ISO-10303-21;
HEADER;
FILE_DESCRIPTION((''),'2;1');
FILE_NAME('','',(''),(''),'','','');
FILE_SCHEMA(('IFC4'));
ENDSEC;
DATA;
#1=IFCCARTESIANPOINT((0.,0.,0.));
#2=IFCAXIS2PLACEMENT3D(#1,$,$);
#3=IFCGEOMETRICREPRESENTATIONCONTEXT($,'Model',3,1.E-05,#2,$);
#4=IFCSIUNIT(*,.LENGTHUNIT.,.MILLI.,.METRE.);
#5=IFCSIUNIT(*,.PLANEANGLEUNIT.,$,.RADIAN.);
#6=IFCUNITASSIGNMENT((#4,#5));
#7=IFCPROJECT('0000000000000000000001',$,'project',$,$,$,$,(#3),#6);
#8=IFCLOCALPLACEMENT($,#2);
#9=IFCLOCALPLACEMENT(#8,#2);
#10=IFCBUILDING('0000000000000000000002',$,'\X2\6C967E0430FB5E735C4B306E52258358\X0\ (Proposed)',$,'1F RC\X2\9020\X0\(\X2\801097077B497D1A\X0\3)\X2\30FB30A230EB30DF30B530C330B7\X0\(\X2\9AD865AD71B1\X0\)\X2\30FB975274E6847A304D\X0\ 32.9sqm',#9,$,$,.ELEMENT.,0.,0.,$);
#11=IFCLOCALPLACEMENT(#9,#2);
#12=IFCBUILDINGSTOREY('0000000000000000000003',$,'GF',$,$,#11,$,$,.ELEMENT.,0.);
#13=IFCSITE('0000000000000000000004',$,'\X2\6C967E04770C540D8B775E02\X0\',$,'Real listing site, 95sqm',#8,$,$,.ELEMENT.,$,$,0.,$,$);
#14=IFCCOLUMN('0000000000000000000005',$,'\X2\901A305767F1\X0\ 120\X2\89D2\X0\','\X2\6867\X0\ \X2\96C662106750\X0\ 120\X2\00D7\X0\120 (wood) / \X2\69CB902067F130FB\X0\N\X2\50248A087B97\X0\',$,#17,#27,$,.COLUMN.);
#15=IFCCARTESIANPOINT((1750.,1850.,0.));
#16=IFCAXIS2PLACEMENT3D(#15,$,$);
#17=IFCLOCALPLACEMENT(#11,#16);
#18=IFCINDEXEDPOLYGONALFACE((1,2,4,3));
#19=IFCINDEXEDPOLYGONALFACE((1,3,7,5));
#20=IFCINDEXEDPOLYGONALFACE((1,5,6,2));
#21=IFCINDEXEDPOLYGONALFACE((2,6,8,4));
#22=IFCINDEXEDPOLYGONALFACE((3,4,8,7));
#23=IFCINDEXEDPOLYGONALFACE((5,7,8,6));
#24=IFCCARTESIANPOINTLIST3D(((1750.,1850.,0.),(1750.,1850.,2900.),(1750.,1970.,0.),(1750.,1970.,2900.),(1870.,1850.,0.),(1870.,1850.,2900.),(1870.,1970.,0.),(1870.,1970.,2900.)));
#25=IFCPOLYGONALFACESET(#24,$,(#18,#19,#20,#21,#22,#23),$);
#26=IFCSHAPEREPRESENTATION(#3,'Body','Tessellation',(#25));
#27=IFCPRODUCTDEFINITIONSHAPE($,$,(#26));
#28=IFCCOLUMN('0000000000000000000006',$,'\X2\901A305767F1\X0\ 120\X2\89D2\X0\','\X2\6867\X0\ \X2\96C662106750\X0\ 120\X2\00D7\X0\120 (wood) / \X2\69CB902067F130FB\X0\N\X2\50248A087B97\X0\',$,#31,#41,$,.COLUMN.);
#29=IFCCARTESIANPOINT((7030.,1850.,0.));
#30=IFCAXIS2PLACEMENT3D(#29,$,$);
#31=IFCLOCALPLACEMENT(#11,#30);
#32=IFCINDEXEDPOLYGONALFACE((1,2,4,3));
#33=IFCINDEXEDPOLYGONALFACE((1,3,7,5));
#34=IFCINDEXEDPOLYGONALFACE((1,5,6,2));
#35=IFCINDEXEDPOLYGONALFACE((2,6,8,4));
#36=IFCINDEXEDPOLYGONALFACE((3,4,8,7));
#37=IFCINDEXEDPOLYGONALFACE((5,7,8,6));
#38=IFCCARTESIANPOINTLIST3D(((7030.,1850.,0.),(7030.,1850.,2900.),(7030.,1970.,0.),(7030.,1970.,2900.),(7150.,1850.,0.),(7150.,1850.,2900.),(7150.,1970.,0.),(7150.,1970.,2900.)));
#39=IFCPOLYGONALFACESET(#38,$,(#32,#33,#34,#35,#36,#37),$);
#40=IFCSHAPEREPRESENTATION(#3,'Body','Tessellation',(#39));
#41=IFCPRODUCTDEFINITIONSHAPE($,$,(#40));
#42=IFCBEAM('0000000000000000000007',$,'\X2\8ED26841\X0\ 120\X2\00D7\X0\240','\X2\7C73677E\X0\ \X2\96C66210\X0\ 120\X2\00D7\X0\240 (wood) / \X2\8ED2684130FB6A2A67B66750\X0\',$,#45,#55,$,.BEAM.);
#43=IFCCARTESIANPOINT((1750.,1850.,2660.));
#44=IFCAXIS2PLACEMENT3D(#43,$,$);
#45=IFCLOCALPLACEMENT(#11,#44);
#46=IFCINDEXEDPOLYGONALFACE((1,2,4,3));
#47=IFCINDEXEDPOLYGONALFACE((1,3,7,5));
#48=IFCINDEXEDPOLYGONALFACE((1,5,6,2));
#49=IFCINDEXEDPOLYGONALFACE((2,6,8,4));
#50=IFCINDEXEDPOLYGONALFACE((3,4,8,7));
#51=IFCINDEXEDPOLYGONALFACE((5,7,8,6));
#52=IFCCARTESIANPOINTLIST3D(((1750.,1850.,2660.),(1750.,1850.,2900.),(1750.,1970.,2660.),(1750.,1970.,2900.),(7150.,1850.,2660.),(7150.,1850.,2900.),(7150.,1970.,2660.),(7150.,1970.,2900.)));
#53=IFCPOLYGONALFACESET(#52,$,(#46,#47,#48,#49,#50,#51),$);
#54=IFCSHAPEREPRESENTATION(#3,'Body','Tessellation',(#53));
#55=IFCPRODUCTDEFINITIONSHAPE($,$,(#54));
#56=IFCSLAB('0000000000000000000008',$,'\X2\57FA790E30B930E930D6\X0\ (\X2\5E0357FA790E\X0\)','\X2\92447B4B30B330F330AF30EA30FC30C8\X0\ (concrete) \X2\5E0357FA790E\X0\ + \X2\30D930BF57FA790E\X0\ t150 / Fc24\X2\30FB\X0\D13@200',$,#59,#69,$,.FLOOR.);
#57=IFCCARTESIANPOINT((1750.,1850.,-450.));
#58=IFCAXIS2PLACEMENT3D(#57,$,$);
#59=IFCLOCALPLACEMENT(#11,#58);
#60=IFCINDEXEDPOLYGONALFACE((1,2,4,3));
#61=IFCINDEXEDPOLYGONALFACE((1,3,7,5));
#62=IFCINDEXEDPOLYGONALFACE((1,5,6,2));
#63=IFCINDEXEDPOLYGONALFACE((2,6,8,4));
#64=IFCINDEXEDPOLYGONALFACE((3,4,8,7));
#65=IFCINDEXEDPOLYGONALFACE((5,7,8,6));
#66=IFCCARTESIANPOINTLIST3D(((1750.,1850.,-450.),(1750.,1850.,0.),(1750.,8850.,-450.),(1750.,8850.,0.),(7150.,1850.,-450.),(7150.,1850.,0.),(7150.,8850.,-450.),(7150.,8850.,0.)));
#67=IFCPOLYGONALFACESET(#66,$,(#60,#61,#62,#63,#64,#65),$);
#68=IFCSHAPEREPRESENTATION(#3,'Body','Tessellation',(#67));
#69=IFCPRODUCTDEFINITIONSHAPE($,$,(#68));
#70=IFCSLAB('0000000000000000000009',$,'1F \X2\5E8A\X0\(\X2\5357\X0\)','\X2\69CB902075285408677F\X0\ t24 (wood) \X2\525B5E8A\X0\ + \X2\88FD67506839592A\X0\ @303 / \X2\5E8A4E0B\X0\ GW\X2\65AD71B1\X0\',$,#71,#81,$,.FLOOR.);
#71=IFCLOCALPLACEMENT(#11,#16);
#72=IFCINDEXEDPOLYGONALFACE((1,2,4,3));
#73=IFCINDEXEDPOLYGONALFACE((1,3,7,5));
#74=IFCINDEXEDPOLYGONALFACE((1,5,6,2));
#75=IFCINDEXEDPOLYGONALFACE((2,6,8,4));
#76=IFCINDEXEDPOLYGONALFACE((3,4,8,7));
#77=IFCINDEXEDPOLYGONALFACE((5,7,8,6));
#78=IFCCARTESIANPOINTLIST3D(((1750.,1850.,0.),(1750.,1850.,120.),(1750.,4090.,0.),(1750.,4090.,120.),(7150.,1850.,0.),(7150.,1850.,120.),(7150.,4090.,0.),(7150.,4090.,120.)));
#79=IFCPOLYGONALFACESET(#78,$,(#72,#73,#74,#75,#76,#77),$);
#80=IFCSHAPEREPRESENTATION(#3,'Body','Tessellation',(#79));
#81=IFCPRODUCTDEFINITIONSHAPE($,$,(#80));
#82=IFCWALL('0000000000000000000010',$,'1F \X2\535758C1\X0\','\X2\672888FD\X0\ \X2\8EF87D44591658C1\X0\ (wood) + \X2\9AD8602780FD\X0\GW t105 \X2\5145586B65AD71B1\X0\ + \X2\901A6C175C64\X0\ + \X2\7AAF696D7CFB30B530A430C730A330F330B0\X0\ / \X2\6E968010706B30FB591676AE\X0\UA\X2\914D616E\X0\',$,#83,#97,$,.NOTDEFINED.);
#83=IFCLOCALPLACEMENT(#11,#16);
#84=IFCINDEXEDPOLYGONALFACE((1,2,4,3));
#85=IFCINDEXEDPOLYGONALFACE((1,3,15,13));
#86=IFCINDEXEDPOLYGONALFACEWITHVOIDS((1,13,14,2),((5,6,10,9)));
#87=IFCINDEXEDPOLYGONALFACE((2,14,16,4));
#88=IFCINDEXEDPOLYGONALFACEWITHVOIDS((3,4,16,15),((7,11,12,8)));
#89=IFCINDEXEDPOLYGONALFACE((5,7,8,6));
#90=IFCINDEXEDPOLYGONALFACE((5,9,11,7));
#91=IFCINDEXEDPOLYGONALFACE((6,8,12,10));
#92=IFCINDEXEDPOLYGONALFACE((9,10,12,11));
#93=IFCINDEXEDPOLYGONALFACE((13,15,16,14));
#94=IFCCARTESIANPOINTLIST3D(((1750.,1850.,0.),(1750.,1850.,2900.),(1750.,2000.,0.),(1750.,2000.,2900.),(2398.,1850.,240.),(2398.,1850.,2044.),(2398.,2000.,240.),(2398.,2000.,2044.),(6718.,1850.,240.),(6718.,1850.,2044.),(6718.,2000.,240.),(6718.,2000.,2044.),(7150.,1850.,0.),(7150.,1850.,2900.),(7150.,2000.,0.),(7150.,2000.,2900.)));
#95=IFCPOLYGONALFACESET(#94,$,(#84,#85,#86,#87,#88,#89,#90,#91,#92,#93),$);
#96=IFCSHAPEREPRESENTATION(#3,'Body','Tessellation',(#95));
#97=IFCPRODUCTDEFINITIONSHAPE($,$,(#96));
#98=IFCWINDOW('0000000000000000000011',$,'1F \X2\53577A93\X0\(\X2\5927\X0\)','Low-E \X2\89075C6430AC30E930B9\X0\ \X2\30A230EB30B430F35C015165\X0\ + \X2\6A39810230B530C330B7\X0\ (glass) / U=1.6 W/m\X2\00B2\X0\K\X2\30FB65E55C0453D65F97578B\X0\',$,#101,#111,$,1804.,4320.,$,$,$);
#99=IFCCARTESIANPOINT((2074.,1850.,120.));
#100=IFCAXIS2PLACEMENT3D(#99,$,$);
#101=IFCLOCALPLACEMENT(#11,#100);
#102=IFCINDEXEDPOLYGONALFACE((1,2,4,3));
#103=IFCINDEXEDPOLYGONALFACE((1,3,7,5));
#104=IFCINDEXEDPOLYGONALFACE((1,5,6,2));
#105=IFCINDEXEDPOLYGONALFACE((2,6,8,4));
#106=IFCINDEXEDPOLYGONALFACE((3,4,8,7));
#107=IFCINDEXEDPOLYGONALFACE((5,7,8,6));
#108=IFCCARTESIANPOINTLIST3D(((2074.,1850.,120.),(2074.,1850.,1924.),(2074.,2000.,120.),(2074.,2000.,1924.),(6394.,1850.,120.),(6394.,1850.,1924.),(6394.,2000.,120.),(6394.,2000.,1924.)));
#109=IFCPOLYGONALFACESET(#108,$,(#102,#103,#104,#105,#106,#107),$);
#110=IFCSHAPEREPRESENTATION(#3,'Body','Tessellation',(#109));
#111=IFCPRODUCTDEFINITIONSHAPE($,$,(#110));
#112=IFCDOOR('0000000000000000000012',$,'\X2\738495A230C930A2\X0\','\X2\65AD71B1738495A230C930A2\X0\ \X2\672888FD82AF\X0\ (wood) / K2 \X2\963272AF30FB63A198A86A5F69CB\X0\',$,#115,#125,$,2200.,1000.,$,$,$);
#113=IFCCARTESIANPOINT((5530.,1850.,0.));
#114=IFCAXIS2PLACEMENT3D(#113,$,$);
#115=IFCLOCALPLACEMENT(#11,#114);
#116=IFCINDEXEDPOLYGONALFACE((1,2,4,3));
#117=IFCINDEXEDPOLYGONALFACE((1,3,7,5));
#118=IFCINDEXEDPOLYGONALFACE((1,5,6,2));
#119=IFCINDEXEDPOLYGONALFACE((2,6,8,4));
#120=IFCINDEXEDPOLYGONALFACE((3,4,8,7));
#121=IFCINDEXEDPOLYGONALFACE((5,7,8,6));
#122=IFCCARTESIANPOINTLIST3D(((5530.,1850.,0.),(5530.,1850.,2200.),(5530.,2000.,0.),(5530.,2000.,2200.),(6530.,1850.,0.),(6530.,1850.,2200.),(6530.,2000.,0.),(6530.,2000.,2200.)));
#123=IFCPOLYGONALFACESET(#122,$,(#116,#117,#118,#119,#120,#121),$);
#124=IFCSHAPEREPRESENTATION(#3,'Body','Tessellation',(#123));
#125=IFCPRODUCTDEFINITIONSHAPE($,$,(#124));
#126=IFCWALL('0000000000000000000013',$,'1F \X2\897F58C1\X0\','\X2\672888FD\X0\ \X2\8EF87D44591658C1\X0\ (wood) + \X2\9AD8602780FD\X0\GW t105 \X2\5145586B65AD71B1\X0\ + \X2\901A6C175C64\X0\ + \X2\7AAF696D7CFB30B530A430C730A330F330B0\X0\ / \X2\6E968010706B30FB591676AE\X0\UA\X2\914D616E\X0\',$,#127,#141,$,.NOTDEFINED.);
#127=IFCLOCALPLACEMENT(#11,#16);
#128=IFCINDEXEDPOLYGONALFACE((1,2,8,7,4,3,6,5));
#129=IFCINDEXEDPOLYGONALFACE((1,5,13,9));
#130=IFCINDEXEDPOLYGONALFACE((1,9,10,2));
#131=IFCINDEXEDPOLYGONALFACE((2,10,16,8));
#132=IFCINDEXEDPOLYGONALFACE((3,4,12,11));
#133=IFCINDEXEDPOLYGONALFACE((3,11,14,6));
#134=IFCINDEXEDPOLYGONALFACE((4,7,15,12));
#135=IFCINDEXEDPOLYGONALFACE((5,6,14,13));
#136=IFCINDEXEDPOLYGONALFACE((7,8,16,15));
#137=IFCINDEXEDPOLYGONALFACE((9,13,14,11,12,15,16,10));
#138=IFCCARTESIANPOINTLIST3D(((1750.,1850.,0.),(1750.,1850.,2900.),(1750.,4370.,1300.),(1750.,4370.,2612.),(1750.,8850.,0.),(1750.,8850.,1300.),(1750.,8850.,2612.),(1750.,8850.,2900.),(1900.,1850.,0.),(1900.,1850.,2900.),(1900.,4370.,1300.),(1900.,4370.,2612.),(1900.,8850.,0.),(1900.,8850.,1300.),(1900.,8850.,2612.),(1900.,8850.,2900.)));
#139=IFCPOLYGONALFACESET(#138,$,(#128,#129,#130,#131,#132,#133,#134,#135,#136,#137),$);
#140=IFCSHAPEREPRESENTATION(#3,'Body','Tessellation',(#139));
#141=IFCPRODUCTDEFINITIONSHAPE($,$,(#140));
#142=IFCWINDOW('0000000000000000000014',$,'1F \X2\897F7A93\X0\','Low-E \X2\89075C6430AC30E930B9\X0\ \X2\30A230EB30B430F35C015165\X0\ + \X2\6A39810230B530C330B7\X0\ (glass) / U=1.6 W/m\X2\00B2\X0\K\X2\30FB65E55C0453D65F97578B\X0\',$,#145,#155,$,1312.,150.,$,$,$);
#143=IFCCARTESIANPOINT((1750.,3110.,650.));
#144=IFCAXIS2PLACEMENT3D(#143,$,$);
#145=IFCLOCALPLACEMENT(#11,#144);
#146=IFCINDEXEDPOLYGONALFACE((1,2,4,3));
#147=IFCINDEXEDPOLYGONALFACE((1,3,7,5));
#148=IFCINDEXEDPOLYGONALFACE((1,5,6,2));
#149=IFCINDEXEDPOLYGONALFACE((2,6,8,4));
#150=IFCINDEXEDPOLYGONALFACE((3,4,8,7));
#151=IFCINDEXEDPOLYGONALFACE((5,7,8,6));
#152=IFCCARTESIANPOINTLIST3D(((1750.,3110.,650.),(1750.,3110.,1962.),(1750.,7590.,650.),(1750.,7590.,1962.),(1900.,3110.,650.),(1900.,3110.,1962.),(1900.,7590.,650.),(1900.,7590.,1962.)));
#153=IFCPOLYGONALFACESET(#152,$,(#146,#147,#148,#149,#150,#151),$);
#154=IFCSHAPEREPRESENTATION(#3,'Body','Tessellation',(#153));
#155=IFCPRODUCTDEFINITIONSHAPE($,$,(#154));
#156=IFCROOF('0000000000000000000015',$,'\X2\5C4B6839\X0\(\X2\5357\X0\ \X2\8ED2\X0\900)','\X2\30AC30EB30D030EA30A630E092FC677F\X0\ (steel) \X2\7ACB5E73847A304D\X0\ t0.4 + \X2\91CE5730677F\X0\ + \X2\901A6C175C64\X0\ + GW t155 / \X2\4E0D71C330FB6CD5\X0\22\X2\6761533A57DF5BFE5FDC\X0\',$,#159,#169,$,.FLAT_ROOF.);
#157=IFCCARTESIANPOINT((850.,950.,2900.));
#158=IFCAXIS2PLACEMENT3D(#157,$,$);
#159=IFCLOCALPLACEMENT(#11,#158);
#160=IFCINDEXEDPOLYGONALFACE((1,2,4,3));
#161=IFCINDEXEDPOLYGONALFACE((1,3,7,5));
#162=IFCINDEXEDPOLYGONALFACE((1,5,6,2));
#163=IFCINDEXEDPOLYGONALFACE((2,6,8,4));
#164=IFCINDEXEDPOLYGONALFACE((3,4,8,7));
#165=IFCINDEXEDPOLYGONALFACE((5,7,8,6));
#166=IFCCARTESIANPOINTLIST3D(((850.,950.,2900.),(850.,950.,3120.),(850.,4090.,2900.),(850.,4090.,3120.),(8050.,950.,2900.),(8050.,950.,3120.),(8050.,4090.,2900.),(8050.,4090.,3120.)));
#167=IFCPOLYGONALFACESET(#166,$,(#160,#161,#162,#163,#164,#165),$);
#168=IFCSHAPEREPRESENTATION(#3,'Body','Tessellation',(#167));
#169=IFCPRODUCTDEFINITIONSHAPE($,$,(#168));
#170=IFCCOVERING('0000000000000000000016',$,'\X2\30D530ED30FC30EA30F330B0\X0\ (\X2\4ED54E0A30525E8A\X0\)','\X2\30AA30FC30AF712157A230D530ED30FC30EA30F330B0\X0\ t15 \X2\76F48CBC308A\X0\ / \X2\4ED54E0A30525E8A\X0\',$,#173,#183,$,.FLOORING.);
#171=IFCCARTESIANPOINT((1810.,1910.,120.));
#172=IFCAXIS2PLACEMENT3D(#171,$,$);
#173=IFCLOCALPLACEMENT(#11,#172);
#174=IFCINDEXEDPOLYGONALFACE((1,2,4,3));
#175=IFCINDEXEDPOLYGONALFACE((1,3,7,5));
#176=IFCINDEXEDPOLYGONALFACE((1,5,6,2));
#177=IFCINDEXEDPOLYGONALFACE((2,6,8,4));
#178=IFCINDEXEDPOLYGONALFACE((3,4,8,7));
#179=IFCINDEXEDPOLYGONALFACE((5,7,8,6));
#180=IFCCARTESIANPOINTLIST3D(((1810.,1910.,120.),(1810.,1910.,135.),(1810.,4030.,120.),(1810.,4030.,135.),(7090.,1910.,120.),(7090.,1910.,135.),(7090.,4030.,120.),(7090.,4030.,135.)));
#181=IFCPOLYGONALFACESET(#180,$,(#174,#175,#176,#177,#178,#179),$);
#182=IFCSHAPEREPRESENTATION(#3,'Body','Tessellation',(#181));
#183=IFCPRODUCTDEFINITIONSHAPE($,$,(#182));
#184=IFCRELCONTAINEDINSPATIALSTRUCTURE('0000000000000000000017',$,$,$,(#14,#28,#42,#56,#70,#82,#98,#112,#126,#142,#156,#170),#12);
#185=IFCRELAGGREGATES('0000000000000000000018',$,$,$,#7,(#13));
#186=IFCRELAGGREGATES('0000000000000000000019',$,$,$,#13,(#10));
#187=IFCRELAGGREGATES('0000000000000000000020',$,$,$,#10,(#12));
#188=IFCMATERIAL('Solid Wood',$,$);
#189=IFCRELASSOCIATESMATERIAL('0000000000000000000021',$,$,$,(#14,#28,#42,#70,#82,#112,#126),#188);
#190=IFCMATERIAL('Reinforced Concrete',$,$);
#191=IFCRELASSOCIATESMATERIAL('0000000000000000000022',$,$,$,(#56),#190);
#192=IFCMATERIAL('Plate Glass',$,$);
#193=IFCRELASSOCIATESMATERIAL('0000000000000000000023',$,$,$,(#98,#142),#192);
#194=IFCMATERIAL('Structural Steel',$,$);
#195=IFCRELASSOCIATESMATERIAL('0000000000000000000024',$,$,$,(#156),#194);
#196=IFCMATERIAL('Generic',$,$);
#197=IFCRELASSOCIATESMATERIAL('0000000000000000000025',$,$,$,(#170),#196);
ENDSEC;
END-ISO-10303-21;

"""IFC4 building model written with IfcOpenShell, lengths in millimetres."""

from ifc_helpers import new_model, si_unit, frame, frame_2d, origin, place, context, project, spatial, rectangle, extrude, material, element, fill, save


model = new_model("IFC4")

# Units and contexts
model_context = context("Model", 3, precision=1e-05, world=origin())
ifc_project = project(units=[si_unit("LENGTHUNIT", "METRE", prefix="MILLI"), si_unit("PLANEANGLEUNIT", "RADIAN")], contexts=[model_context])

# Site, building, storey
site_placement = place(None, origin())
site = spatial("IfcSite", under=ifc_project, at=site_placement, Name="沖縄県名護市", ObjectType="Real listing site, 95sqm", CompositionType="ELEMENT", RefElevation=0.0)
building_placement = place(site_placement, origin())
building = spatial("IfcBuilding", under=site, at=building_placement, Name="沖縄・平屋の別荘 (Proposed)", ObjectType="1F RC造(耐震等級3)・アルミサッシ(高断熱)・青瓦葺き 32.9sqm", CompositionType="ELEMENT", ElevationOfRefHeight=0.0, ElevationOfTerrain=0.0)
storey_placement = place(building_placement, origin())
storey = spatial("IfcBuildingStorey", under=building, at=storey_placement, Name="GF", CompositionType="ELEMENT", Elevation=0.0)

# Columns
ifc_material_1 = material(Name="Solid Wood")
column_1_placement = place(storey_placement, frame((1750.0, 1850.0, 0.0)))
element("IfcColumn", 1, at=column_1_placement, inside=storey, material=ifc_material_1, Name="通し柱 120角", Description="桧 集成材 120×120 (wood) / 構造柱・N値計算", PredefinedType="COLUMN", context=model_context, shape_type="SweptSolid", body=[
    extrude(rectangle(XDim=120.0, YDim=120.0, at=frame_2d((60.0, 60.0))), frame((1750.0, 1850.0, 0.0)), (0.0, 0.0, 1.0), 2900.0),
])
column_2_placement = place(storey_placement, frame((7030.0, 1850.0, 0.0)))
element("IfcColumn", 2, at=column_2_placement, inside=storey, material=ifc_material_1, Name="通し柱 120角", Description="桧 集成材 120×120 (wood) / 構造柱・N値計算", PredefinedType="COLUMN", context=model_context, shape_type="SweptSolid", body=[
    extrude(rectangle(XDim=120.0, YDim=120.0, at=frame_2d((60.0, 60.0))), frame((7030.0, 1850.0, 0.0)), (0.0, 0.0, 1.0), 2900.0),
])

# Beam
beam_1_placement = place(storey_placement, frame((1750.0, 1850.0, 2660.0)))
element("IfcBeam", 3, at=beam_1_placement, inside=storey, material=ifc_material_1, Name="軒桁 120×240", Description="米松 集成 120×240 (wood) / 軒桁・横架材", PredefinedType="BEAM", context=model_context, shape_type="SweptSolid", body=[
    extrude(rectangle(XDim=5400.0, YDim=120.0, at=frame_2d((2700.0, 60.0))), frame((1750.0, 1850.0, 2660.0)), (0.0, 0.0, 1.0), 240.0),
])

# Slabs
ifc_material_2 = material(Name="Reinforced Concrete")
slab_1_placement = place(storey_placement, frame((1750.0, 1850.0, -450.0)))
element("IfcSlab", 4, at=slab_1_placement, inside=storey, material=ifc_material_2, Name="基礎スラブ (布基礎)", Description="鉄筋コンクリート (concrete) 布基礎 + ベタ基礎 t150 / Fc24・D13@200", PredefinedType="FLOOR", context=model_context, shape_type="SweptSolid", body=[
    extrude(rectangle(XDim=5400.0, YDim=7000.0, at=frame_2d((2700.0, 3500.0))), frame((1750.0, 1850.0, -450.0)), (0.0, 0.0, 1.0), 450.0),
])
slab_2_placement = place(storey_placement, frame((1750.0, 1850.0, 0.0)))
element("IfcSlab", 5, at=slab_2_placement, inside=storey, material=ifc_material_1, Name="1F 床(南)", Description="構造用合板 t24 (wood) 剛床 + 製材根太 @303 / 床下 GW断熱", PredefinedType="FLOOR", context=model_context, shape_type="SweptSolid", body=[
    extrude(rectangle(XDim=5400.0, YDim=2240.0, at=frame_2d((2700.0, 1120.0))), frame((1750.0, 1850.0, 0.0)), (0.0, 0.0, 1.0), 120.0),
])

# Wall, openings, window, door
wall_1_placement = place(storey_placement, frame((1750.0, 1850.0, 0.0)))
wall_1 = element("IfcWall", 6, at=wall_1_placement, inside=storey, material=ifc_material_1, Name="1F 南壁", Description="木製 軸組外壁 (wood) + 高性能GW t105 充填断熱 + 通気層 + 窯業系サイディング / 準耐火・外皮UA配慮", PredefinedType="NOTDEFINED", context=model_context, shape_type="SweptSolid", body=[
    extrude(rectangle(XDim=5400.0, YDim=150.0, at=frame_2d((2700.0, 75.0))), frame((1750.0, 1850.0, 0.0)), (0.0, 0.0, 1.0), 2900.0),
])
opening_1_placement = place(storey_placement, frame((2074.0, 1850.0, 120.0)))
opening_1 = element("IfcOpeningElement", 7, at=opening_1_placement, cuts=wall_1, PredefinedType="NOTDEFINED", context=model_context, shape_type="SweptSolid", body=[
    extrude(rectangle(XDim=4320.0, YDim=150.0, at=frame_2d((2160.0, 75.0))), frame((2074.0, 1850.0, 120.0)), (0.0, 0.0, 1.0), 1804.0),
])
opening_2_placement = place(storey_placement, frame((5530.0, 1850.0, 0.0)))
opening_2 = element("IfcOpeningElement", 8, at=opening_2_placement, cuts=wall_1, PredefinedType="NOTDEFINED", context=model_context, shape_type="SweptSolid", body=[
    extrude(rectangle(XDim=1000.0, YDim=150.0, at=frame_2d((500.0, 75.0))), frame((5530.0, 1850.0, 0.0)), (0.0, 0.0, 1.0), 2200.0),
])
ifc_material_3 = material(Name="Plate Glass")
window_1_placement = place(storey_placement, frame((2074.0, 1850.0, 120.0)))
window_1 = element("IfcWindow", 9, at=window_1_placement, inside=storey, material=ifc_material_3, Name="1F 南窓(大)", Description="Low-E 複層ガラス アルゴン封入 + 樹脂サッシ (glass) / U=1.6 W/m²K・日射取得型", OverallHeight=1804.0, OverallWidth=4320.0, context=model_context, shape_type="SweptSolid", body=[
    extrude(rectangle(XDim=4320.0, YDim=150.0, at=frame_2d((2160.0, 75.0))), frame((2074.0, 1850.0, 120.0)), (0.0, 0.0, 1.0), 1804.0),
])
fill(opening_1, window_1)
door_placement = place(storey_placement, frame((5530.0, 1850.0, 0.0)))
door = element("IfcDoor", 10, at=door_placement, inside=storey, material=ifc_material_1, Name="玄関ドア", Description="断熱玄関ドア 木製芯 (wood) / K2 防犯・採風機構", OverallHeight=2200.0, OverallWidth=1000.0, context=model_context, shape_type="SweptSolid", body=[
    extrude(rectangle(XDim=1000.0, YDim=150.0, at=frame_2d((500.0, 75.0))), frame((5530.0, 1850.0, 0.0)), (0.0, 0.0, 1.0), 2200.0),
])
fill(opening_2, door)

# Wall, opening, window
wall_2_placement = place(storey_placement, frame((1750.0, 1850.0, 0.0)))
wall_2 = element("IfcWall", 11, at=wall_2_placement, inside=storey, material=ifc_material_1, Name="1F 西壁", Description="木製 軸組外壁 (wood) + 高性能GW t105 充填断熱 + 通気層 + 窯業系サイディング / 準耐火・外皮UA配慮", PredefinedType="NOTDEFINED", context=model_context, shape_type="SweptSolid", body=[
    extrude(rectangle(XDim=150.0, YDim=7000.0, at=frame_2d((75.0, 3500.0))), frame((1750.0, 1850.0, 0.0)), (0.0, 0.0, 1.0), 2900.0),
])
opening_3_placement = place(storey_placement, frame((1750.0, 3110.0, 650.0)))
opening_3 = element("IfcOpeningElement", 12, at=opening_3_placement, cuts=wall_2, PredefinedType="NOTDEFINED", context=model_context, shape_type="SweptSolid", body=[
    extrude(rectangle(XDim=150.0, YDim=4480.0, at=frame_2d((75.0, 2240.0))), frame((1750.0, 3110.0, 650.0)), (0.0, 0.0, 1.0), 1312.0),
])
window_2_placement = place(storey_placement, frame((1750.0, 3110.0, 650.0)))
window_2 = element("IfcWindow", 13, at=window_2_placement, inside=storey, material=ifc_material_3, Name="1F 西窓", Description="Low-E 複層ガラス アルゴン封入 + 樹脂サッシ (glass) / U=1.6 W/m²K・日射取得型", OverallHeight=1312.0, OverallWidth=150.0, context=model_context, shape_type="SweptSolid", body=[
    extrude(rectangle(XDim=150.0, YDim=4480.0, at=frame_2d((75.0, 2240.0))), frame((1750.0, 3110.0, 650.0)), (0.0, 0.0, 1.0), 1312.0),
])
fill(opening_3, window_2)

# Roof
ifc_material_4 = material(Name="Structural Steel")
roof_placement = place(storey_placement, frame((850.0, 950.0, 2900.0)))
element("IfcRoof", 14, at=roof_placement, inside=storey, material=ifc_material_4, Name="屋根(南 軒900)", Description="ガルバリウム鋼板 (steel) 立平葺き t0.4 + 野地板 + 通気層 + GW t155 / 不燃・法22条区域対応", PredefinedType="FLAT_ROOF", context=model_context, shape_type="SweptSolid", body=[
    extrude(rectangle(XDim=7200.0, YDim=3140.0, at=frame_2d((3600.0, 1570.0))), frame((850.0, 950.0, 2900.0)), (0.0, 0.0, 1.0), 220.0),
])

# Covering
ifc_material_5 = material(Name="Generic")
covering_1_placement = place(storey_placement, frame((1810.0, 1910.0, 120.0)))
element("IfcCovering", 15, at=covering_1_placement, inside=storey, material=ifc_material_5, Name="フローリング (仕上げ床)", Description="オーク無垢フローリング t15 直貼り / 仕上げ床", PredefinedType="FLOORING", context=model_context, shape_type="SweptSolid", body=[
    extrude(rectangle(XDim=5280.0, YDim=2120.0, at=frame_2d((2640.0, 1060.0))), frame((1810.0, 1910.0, 120.0)), (0.0, 0.0, 1.0), 15.0),
])

save(model, "model.ifc")
